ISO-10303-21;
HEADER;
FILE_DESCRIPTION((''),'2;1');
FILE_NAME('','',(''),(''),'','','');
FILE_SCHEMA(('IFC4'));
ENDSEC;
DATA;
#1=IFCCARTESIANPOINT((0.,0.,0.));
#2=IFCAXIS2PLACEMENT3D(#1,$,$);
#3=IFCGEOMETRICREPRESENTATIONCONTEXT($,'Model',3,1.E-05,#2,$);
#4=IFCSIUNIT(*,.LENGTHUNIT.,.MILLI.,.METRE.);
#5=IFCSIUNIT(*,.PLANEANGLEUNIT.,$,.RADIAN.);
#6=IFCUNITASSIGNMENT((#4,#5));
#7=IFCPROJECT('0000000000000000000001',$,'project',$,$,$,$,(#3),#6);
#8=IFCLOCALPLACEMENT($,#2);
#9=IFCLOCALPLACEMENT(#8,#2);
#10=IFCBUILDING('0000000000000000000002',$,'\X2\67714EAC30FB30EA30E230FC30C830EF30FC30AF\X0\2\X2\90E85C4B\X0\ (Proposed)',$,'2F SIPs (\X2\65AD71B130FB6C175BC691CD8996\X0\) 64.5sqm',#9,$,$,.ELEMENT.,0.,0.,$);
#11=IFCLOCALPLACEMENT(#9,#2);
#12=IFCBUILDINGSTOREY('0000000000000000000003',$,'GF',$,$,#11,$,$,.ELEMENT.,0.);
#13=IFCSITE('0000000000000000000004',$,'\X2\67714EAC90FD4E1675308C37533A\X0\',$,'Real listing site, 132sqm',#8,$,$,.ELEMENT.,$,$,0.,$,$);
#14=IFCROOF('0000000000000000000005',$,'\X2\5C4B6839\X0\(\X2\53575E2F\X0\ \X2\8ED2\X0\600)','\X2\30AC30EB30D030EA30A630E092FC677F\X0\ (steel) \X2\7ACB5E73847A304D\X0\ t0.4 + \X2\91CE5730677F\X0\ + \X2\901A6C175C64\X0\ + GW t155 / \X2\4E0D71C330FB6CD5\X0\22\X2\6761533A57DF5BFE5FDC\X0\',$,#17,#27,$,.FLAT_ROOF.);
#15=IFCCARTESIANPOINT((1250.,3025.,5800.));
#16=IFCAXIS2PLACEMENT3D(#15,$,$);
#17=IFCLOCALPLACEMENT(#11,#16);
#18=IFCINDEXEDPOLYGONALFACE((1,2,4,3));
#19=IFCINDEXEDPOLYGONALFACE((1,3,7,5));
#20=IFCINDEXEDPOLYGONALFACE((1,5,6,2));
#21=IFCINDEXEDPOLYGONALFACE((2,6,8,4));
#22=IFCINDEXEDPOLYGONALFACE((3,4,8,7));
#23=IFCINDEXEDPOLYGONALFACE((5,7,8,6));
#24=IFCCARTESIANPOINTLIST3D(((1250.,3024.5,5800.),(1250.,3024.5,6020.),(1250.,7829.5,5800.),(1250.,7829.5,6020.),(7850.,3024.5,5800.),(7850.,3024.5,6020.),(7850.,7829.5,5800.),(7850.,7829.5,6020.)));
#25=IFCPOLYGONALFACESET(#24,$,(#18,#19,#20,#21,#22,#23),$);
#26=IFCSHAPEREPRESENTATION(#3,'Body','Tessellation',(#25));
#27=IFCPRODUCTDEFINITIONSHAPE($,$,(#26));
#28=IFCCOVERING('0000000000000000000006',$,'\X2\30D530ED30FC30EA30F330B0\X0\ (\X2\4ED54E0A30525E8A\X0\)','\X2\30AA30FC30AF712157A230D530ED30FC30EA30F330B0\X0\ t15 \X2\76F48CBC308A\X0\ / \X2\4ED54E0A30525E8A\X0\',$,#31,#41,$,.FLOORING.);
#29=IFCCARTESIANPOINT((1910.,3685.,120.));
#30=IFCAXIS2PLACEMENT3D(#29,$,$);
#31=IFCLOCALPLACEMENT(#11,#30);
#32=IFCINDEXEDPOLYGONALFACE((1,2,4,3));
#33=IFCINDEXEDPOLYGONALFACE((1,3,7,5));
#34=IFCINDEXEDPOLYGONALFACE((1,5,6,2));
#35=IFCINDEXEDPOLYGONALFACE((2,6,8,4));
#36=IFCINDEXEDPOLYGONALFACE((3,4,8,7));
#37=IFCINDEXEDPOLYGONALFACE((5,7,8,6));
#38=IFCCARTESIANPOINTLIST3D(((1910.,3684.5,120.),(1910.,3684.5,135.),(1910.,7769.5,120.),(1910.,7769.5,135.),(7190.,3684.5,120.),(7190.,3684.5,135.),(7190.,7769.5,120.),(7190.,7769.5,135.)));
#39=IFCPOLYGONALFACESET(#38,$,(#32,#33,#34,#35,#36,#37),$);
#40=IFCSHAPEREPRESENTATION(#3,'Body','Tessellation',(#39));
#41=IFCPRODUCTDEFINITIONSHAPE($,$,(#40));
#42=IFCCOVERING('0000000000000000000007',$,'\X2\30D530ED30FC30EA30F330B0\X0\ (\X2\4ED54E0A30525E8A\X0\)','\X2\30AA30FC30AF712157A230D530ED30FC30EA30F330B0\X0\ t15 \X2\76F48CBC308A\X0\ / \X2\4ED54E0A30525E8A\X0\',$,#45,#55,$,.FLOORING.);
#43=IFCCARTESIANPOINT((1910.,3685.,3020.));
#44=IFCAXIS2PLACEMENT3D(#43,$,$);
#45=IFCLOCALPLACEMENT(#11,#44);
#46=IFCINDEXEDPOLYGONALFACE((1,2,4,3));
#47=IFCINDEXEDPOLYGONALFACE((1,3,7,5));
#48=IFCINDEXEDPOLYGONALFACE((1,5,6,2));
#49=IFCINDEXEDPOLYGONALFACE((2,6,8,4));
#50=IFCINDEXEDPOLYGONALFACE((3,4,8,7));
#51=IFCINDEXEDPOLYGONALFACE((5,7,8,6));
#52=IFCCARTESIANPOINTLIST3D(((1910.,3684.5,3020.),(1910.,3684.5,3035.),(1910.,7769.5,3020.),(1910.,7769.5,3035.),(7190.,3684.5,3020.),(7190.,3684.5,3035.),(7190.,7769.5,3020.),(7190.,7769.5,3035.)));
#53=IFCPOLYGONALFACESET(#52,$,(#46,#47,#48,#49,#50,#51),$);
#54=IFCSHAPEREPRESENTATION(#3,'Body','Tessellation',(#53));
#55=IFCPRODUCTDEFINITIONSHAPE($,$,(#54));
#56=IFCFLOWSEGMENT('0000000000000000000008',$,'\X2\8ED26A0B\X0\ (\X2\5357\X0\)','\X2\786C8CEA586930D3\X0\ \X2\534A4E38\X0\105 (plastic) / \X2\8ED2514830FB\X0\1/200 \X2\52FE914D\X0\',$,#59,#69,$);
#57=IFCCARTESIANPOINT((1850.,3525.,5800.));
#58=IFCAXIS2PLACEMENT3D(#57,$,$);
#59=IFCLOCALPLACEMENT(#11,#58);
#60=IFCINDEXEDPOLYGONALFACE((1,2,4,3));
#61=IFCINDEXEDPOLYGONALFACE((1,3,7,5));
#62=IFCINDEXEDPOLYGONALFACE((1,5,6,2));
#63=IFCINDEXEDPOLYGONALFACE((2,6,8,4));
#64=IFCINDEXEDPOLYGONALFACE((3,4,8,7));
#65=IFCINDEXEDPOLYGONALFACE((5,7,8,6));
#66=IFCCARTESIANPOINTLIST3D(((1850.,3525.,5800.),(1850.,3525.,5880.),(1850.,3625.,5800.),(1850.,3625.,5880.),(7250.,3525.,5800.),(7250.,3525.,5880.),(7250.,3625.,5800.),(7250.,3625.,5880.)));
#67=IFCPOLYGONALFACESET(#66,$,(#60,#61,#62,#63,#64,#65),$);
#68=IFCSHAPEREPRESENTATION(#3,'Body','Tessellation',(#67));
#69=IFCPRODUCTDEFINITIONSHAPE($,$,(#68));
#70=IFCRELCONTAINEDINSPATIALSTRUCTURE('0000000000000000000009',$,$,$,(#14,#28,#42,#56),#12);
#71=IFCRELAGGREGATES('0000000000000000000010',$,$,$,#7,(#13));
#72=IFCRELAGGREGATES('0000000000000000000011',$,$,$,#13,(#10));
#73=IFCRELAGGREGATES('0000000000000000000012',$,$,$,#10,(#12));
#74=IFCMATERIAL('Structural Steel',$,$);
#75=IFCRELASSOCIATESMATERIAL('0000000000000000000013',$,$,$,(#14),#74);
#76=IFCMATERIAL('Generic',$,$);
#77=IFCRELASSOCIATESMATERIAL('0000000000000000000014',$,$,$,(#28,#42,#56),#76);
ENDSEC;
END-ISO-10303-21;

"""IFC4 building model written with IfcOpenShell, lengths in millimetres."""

from ifc_helpers import new_model, si_unit, frame, frame_2d, origin, place, context, project, spatial, rectangle, extrude, material, element, save


model = new_model("IFC4")

# Units and contexts
model_context = context("Model", 3, precision=1e-05, world=origin())
ifc_project = project(units=[si_unit("LENGTHUNIT", "METRE", prefix="MILLI"), si_unit("PLANEANGLEUNIT", "RADIAN")], contexts=[model_context])

# Site, building, storey
site_placement = place(None, origin())
site = spatial("IfcSite", under=ifc_project, at=site_placement, Name="東京都世田谷区", ObjectType="Real listing site, 132sqm", CompositionType="ELEMENT", RefElevation=0.0)
building_placement = place(site_placement, origin())
building = spatial("IfcBuilding", under=site, at=building_placement, Name="東京・リモートワーク2部屋 (Proposed)", ObjectType="2F SIPs (断熱・気密重視) 64.5sqm", CompositionType="ELEMENT", ElevationOfRefHeight=0.0, ElevationOfTerrain=0.0)
storey_placement = place(building_placement, origin())
storey = spatial("IfcBuildingStorey", under=building, at=storey_placement, Name="GF", CompositionType="ELEMENT", Elevation=0.0)

# Roof
ifc_material_1 = material(Name="Structural Steel")
for number, where, name in (
    (1, (1250.0, 3025.0, 5800.0), "屋根(南帯 軒600)"),
):
    element("IfcRoof", number, at=place(storey_placement, frame(where)), inside=storey, material=ifc_material_1, Name=name, Description="ガルバリウム鋼板 (steel) 立平葺き t0.4 + 野地板 + 通気層 + GW t155 / 不燃・法22条区域対応", PredefinedType="FLAT_ROOF", context=model_context, shape_type="SweptSolid", body=[
        extrude(rectangle(XDim=6600.0, YDim=4805.0, at=frame_2d((3300.0, 2402.0))), frame((1250.0, 3025.0, 5800.0)), (0.0, 0.0, 1.0), 220.0),
    ])

# Coverings
ifc_material_2 = material(Name="Generic")
covering_1_placement = place(storey_placement, frame((1910.0, 3685.0, 120.0)))
element("IfcCovering", 2, at=covering_1_placement, inside=storey, material=ifc_material_2, Name="フローリング (仕上げ床)", Description="オーク無垢フローリング t15 直貼り / 仕上げ床", PredefinedType="FLOORING", context=model_context, shape_type="SweptSolid", body=[
    extrude(rectangle(XDim=5280.0, YDim=4085.0, at=frame_2d((2640.0, 2042.0))), frame((1910.0, 3685.0, 120.0)), (0.0, 0.0, 1.0), 15.0),
])
covering_2_placement = place(storey_placement, frame((1910.0, 3685.0, 3020.0)))
element("IfcCovering", 3, at=covering_2_placement, inside=storey, material=ifc_material_2, Name="フローリング (仕上げ床)", Description="オーク無垢フローリング t15 直貼り / 仕上げ床", PredefinedType="FLOORING", context=model_context, shape_type="SweptSolid", body=[
    extrude(rectangle(XDim=5280.0, YDim=4085.0, at=frame_2d((2640.0, 2042.0))), frame((1910.0, 3685.0, 3020.0)), (0.0, 0.0, 1.0), 15.0),
])

# Flow segment
flow_segment_placement = place(storey_placement, frame((1850.0, 3525.0, 5800.0)))
element("IfcFlowSegment", 4, at=flow_segment_placement, inside=storey, material=ifc_material_2, Name="軒樋 (南)", Description="硬質塩ビ 半丸105 (plastic) / 軒先・1/200 勾配", context=model_context, shape_type="SweptSolid", body=[
    extrude(rectangle(XDim=5400.0, YDim=100.0, at=frame_2d((2700.0, 50.0))), frame((1850.0, 3525.0, 5800.0)), (0.0, 0.0, 1.0), 80.0),
])

save(model, "model.ifc")
